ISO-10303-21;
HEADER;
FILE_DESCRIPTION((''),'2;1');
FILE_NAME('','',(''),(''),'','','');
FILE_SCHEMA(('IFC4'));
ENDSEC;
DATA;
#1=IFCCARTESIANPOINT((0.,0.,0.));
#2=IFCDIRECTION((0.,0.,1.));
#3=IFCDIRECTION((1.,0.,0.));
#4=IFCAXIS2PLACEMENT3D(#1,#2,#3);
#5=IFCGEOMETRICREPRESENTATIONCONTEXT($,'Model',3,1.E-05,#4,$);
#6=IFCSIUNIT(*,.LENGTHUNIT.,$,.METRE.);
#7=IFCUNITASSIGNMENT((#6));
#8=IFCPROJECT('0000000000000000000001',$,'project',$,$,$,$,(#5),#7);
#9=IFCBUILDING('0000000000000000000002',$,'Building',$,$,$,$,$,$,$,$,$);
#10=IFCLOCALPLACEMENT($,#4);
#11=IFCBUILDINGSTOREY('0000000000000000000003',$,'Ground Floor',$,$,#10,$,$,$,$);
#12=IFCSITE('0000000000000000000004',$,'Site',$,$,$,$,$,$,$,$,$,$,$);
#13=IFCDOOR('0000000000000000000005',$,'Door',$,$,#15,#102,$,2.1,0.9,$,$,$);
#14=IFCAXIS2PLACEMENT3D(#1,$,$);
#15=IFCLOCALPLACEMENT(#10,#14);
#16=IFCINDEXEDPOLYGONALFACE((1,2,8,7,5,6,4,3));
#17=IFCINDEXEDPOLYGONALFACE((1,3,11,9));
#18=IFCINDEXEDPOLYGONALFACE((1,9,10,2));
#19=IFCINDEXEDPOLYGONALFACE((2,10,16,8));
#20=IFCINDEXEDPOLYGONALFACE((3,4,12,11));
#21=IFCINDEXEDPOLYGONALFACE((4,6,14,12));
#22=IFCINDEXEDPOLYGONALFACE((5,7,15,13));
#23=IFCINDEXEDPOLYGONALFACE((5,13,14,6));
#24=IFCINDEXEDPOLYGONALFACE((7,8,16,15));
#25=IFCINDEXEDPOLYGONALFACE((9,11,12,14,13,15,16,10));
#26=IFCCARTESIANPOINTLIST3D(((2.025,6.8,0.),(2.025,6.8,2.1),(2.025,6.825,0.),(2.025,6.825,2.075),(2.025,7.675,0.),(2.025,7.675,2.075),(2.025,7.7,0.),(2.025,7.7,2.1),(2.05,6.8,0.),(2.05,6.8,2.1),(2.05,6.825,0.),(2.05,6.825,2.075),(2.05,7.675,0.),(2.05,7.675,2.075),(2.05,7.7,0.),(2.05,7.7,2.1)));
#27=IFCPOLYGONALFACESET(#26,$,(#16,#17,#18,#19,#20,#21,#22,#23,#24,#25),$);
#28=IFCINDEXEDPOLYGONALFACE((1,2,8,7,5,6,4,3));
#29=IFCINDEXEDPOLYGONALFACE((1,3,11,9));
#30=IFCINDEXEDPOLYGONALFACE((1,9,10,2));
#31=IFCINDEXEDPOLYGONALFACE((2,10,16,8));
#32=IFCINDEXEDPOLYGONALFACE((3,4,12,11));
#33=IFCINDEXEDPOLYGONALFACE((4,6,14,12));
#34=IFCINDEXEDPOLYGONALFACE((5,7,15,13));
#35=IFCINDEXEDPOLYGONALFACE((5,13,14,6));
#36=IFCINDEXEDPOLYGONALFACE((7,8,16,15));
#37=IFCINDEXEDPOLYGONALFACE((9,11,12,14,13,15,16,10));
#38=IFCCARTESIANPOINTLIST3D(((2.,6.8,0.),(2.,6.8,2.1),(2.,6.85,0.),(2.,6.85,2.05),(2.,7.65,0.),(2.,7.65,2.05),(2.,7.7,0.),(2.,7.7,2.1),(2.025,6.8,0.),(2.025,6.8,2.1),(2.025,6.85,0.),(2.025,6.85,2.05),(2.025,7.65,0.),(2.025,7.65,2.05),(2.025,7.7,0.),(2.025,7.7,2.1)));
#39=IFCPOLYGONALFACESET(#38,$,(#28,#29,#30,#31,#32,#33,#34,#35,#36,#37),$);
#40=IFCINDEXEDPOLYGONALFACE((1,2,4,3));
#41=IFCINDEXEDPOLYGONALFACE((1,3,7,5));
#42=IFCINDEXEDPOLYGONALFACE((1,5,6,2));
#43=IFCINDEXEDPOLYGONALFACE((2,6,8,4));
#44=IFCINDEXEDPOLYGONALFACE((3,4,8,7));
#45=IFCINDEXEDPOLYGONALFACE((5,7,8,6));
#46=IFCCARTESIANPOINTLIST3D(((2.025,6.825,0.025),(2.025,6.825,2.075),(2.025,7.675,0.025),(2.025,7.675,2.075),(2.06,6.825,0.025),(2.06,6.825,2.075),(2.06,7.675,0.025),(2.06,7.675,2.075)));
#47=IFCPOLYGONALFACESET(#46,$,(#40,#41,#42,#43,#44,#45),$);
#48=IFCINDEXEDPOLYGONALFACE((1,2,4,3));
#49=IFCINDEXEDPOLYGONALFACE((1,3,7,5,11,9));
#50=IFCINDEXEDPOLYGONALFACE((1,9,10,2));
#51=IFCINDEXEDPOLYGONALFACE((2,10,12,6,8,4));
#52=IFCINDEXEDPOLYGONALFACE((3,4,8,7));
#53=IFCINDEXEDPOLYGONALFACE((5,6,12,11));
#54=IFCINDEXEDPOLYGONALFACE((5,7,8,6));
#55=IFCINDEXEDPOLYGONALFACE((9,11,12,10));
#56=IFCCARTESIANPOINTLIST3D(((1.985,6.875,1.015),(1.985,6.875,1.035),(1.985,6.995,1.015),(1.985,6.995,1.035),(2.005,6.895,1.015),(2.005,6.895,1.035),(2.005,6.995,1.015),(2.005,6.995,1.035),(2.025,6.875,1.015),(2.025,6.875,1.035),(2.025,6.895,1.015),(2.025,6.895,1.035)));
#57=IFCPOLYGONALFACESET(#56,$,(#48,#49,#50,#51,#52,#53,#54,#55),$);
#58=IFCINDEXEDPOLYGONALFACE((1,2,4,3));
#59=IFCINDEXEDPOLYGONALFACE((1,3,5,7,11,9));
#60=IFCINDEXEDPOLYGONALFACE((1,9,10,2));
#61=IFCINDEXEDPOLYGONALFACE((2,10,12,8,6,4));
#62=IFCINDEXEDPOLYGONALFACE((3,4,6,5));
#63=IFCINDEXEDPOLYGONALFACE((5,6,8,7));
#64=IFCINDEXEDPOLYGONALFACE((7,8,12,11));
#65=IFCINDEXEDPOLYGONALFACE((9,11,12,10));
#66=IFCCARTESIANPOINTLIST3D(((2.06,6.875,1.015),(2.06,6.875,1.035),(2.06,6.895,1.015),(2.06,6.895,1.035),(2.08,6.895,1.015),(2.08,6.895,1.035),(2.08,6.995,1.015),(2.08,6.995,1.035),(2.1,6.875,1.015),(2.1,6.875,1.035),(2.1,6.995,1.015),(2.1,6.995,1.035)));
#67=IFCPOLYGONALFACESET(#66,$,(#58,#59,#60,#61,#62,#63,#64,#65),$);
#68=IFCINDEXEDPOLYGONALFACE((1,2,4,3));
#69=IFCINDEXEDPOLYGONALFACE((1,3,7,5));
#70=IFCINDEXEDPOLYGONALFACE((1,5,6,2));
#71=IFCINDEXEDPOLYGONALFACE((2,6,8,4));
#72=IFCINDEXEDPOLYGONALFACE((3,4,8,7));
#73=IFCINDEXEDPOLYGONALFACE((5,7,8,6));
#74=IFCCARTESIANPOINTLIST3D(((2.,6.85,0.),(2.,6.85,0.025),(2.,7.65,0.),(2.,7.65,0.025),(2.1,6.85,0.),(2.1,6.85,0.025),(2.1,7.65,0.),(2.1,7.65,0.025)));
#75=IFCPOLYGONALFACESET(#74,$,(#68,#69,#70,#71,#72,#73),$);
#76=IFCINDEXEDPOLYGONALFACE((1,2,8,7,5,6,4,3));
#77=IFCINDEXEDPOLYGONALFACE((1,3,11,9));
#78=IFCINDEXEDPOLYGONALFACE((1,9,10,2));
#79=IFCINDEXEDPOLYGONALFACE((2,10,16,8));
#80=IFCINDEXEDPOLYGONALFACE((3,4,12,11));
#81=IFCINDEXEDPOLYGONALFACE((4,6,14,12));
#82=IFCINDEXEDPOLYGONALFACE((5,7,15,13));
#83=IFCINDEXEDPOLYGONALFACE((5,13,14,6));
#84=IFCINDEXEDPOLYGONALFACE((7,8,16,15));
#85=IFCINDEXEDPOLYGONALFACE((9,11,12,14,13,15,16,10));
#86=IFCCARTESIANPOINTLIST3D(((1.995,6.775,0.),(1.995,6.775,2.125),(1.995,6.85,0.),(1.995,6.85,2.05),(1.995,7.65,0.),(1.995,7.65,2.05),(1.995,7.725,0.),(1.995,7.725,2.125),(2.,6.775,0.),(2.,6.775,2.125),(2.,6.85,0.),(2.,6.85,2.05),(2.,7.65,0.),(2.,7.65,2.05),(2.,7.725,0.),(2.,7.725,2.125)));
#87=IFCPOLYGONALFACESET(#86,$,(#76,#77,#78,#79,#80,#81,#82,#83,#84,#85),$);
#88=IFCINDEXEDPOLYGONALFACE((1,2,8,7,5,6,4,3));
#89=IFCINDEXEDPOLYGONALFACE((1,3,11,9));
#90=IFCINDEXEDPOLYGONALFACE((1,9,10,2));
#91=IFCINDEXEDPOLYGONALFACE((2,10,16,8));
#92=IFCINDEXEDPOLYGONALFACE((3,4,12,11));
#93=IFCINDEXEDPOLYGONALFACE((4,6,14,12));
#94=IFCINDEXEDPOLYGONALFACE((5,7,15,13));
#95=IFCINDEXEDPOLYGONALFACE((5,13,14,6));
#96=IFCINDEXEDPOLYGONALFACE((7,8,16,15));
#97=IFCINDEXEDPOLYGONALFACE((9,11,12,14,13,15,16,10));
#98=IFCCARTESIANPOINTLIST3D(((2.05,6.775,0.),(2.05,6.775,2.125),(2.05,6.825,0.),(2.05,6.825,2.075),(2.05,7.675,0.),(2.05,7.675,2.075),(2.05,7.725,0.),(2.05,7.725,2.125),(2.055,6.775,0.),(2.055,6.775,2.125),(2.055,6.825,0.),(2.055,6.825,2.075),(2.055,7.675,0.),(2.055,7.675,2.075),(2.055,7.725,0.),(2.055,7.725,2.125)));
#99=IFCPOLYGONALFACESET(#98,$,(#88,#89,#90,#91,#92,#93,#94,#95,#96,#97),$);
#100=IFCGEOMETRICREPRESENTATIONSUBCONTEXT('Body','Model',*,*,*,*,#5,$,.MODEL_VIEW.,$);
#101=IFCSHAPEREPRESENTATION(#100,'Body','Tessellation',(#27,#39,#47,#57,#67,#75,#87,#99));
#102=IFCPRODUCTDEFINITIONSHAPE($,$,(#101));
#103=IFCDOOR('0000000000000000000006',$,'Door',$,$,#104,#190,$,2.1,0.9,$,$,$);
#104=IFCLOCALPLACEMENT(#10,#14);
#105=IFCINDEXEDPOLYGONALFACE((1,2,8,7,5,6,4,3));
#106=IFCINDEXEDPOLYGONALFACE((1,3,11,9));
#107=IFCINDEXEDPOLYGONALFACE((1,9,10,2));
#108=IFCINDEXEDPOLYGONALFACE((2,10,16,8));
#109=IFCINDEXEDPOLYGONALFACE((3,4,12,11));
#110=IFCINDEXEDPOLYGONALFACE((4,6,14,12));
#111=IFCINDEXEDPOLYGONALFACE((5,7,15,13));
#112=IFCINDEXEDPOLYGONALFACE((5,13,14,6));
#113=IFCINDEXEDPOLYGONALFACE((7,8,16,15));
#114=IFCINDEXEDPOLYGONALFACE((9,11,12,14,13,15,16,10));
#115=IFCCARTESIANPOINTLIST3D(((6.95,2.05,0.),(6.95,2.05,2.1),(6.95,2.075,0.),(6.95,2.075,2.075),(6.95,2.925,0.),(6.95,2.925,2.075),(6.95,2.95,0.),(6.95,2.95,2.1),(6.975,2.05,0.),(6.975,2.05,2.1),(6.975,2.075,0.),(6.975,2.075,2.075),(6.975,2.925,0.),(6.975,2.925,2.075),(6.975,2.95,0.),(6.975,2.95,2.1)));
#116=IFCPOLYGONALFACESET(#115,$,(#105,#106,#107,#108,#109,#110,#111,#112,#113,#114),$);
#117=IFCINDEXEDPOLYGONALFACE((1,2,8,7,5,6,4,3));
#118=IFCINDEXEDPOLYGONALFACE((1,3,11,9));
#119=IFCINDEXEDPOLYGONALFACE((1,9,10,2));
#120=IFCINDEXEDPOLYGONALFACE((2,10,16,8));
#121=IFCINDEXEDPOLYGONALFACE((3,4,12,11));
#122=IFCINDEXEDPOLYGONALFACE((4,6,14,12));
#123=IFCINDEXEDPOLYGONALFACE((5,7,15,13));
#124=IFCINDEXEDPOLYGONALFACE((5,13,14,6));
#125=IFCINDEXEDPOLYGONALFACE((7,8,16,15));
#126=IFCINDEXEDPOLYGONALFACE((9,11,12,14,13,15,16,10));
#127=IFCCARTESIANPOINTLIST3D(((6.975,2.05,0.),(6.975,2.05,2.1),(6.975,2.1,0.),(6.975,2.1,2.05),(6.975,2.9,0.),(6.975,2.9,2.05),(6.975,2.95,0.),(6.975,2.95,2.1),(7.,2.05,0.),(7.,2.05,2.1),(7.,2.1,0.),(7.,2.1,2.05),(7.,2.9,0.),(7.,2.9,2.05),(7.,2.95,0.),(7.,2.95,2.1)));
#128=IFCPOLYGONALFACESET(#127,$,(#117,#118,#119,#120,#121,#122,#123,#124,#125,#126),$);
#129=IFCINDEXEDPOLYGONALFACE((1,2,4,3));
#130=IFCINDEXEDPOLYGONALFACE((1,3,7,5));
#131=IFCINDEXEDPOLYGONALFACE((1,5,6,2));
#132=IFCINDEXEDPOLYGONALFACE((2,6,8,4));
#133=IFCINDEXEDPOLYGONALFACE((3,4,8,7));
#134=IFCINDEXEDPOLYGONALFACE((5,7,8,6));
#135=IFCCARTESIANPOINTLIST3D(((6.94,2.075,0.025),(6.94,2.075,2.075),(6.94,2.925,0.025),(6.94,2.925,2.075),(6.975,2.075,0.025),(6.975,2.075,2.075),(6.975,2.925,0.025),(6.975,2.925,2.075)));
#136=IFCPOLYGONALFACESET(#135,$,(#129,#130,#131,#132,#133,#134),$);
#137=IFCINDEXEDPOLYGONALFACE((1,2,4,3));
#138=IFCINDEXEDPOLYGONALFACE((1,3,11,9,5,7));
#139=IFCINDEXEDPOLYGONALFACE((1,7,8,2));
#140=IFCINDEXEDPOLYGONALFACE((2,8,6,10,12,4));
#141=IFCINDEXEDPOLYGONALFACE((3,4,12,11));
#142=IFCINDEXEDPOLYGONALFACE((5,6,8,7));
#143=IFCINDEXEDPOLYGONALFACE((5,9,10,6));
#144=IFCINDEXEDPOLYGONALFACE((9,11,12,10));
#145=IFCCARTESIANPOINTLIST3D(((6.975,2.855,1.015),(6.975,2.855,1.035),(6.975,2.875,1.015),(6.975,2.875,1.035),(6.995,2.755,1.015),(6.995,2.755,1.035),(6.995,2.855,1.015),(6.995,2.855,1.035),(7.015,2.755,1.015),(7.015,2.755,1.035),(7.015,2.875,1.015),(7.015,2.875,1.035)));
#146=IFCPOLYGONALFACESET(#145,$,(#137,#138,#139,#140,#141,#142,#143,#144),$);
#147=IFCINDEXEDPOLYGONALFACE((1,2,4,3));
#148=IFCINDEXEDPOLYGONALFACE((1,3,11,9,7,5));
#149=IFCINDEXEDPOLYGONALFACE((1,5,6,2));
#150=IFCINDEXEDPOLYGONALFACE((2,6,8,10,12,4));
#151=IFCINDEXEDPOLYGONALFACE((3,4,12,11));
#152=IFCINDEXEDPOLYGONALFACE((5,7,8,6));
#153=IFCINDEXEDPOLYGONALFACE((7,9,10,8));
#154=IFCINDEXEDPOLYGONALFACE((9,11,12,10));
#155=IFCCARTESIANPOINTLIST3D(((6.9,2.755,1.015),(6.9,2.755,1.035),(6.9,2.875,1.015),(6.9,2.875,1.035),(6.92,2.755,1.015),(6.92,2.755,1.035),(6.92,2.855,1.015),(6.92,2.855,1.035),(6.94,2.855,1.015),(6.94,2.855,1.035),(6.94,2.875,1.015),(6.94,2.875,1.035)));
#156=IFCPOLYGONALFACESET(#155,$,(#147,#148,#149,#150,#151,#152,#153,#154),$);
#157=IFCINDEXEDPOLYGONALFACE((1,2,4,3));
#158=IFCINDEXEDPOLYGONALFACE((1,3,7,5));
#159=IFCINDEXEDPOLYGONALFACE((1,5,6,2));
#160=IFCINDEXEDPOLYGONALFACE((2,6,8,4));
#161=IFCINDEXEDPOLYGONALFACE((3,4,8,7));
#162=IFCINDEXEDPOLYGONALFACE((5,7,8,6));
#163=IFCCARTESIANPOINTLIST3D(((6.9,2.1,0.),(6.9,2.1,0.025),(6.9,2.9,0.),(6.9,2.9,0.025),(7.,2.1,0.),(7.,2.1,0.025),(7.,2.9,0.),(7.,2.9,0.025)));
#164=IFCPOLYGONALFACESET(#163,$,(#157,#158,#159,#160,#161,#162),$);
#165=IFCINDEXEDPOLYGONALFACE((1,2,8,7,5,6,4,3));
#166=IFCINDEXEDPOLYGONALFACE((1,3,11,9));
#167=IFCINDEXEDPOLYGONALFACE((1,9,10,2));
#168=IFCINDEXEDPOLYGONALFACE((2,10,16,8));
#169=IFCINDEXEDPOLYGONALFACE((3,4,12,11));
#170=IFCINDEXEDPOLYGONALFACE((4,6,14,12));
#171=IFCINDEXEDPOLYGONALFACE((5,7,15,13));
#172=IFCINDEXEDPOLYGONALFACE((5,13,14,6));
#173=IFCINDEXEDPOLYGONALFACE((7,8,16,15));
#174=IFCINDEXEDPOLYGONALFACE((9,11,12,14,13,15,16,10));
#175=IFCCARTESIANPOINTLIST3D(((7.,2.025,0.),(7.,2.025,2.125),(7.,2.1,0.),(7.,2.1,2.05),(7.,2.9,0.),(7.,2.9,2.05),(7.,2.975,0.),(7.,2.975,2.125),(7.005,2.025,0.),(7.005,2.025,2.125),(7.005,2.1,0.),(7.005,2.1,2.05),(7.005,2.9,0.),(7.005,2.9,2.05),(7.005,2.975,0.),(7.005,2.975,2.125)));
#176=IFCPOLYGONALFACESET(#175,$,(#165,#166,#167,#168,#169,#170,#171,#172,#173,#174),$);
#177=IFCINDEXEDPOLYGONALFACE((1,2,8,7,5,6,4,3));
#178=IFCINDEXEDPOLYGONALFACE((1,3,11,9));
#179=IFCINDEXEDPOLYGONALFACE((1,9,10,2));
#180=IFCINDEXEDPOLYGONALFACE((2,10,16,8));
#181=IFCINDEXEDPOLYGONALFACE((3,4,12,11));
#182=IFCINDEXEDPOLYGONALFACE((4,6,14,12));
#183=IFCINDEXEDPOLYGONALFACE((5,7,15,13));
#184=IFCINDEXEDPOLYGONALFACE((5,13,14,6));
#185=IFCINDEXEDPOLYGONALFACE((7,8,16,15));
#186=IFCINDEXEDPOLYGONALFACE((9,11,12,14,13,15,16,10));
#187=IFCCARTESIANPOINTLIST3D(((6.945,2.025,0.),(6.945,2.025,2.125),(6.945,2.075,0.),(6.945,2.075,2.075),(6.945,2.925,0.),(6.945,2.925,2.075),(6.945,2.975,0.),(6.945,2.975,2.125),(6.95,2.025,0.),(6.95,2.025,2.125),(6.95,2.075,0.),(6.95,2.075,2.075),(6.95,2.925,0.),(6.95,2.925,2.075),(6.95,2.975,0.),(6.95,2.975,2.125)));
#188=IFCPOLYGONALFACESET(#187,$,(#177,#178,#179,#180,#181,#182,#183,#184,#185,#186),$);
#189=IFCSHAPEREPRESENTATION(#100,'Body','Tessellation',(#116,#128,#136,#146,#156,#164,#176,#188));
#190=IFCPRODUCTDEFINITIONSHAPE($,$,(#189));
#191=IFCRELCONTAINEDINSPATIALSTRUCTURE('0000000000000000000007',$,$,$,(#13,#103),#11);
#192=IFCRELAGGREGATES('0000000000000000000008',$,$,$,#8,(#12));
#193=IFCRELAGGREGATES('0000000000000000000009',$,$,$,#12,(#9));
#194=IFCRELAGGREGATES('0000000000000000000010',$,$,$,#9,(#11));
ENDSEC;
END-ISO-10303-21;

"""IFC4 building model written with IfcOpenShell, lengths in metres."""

from ifc_helpers import new_model, si_unit, frame, origin_with_axes, place, context, subcontext, project, spatial, line, indexed_curve, outline, extrude, element, save


model = new_model("IFC4")

# Units and contexts
model_context = context("Model", 3, precision=1e-05, world=origin_with_axes())
body_context = subcontext(model_context, "Body", "Model", "MODEL_VIEW")
ifc_project = project(units=[si_unit("LENGTHUNIT", "METRE")], contexts=[model_context])

# Site, building, storey
site = spatial("IfcSite", under=ifc_project, Name="Site")
building = spatial("IfcBuilding", under=site, Name="Building")
storey_placement = place(None, origin_with_axes())
storey = spatial("IfcBuildingStorey", under=building, at=storey_placement, Name="Ground Floor")

# Doors
door_1_placement = place(storey_placement, frame((2.0, 7.7, 0.0), z_axis=(0.0, 0.0, 1.0), x_axis=(0.0, -1.0, 0.0)))
element("IfcDoor", 1, at=door_1_placement, inside=storey, Name="Door", OverallHeight=2.1, OverallWidth=0.9, context=body_context, shape_type="SweptSolid", body=[
    extrude(outline(indexed_curve([(0.0, 0.0), (0.0, 2.1), (0.9, 2.1), (0.9, 0.0), (0.875, 0.0), (0.875, 2.075), (0.025, 2.075), (0.025, 0.0)], segments=[line(1, 2, 3, 4, 5, 6, 7, 8, 1)])), frame((0.0, 0.025, 0.0), z_axis=(0.0, -1.0, 0.0), x_axis=(1.0, 0.0, 0.0)), (0.0, 0.0, -1.0), 0.025),
    extrude(outline(indexed_curve([(0.0, 0.0), (0.0, 2.1), (0.9, 2.1), (0.9, 0.0), (0.85, 0.0), (0.85, 2.05), (0.05, 2.05), (0.05, 0.0)], segments=[line(1, 2, 3, 4, 5, 6, 7, 8, 1)])), frame((0.0, 0.0, 0.0), z_axis=(0.0, -1.0, 0.0), x_axis=(1.0, 0.0, 0.0)), (0.0, 0.0, -1.0), 0.025),
    extrude(outline(indexed_curve([(0.0, 0.0), (0.85, 0.0), (0.85, 0.035), (0.0, 0.035)], segments=[line(1, 2, 3, 4, 1)])), frame((0.025, 0.025, 0.025), z_axis=(0.0, 0.0, 1.0), x_axis=(1.0, 0.0, 0.0)), (0.0, 0.0, 1.0), 2.05),
    extrude(outline(indexed_curve([(0.0, 0.0), (0.0, -0.04), (-0.12, -0.04), (-0.12, -0.02), (-0.02, -0.02), (-0.02, 0.0)], segments=[line(1, 2, 3, 4, 5, 6, 1)])), frame((0.825, 0.025, 1.015), z_axis=(0.0, 0.0, 1.0), x_axis=(1.0, 0.0, 0.0)), (0.0, 0.0, 1.0), 0.02),
    extrude(outline(indexed_curve([(0.0, 0.0), (0.0, 0.04), (-0.12, 0.04), (-0.12, 0.02), (-0.02, 0.02), (-0.02, 0.0)], segments=[line(1, 2, 3, 4, 5, 6, 1)])), frame((0.825, 0.06, 1.015), z_axis=(0.0, 0.0, 1.0), x_axis=(1.0, 0.0, 0.0)), (0.0, 0.0, 1.0), 0.02),
    extrude(outline(indexed_curve([(0.0, 0.0), (0.8, 0.0), (0.8, 0.1), (0.0, 0.1)], segments=[line(1, 2, 3, 4, 1)])), frame((0.05, 0.0, 0.0), z_axis=(0.0, 0.0, 1.0), x_axis=(1.0, 0.0, 0.0)), (0.0, 0.0, 1.0), 0.025),
    extrude(outline(indexed_curve([(0.0, 0.0), (0.0, 2.125), (0.95, 2.125), (0.95, 0.0), (0.875, 0.0), (0.875, 2.05), (0.075, 2.05), (0.075, 0.0)], segments=[line(1, 2, 3, 4, 5, 6, 7, 8, 1)])), frame((-0.025, -0.005, 0.0), z_axis=(0.0, -1.0, 0.0), x_axis=(1.0, 0.0, 0.0)), (0.0, 0.0, -1.0), 0.005),
    extrude(outline(indexed_curve([(0.0, 0.0), (0.0, 2.125), (0.95, 2.125), (0.95, 0.0), (0.9, 0.0), (0.9, 2.075), (0.05, 2.075), (0.05, 0.0)], segments=[line(1, 2, 3, 4, 5, 6, 7, 8, 1)])), frame((-0.025, 0.05, 0.0), z_axis=(0.0, -1.0, 0.0), x_axis=(1.0, 0.0, 0.0)), (0.0, 0.0, -1.0), 0.005),
])
door_2_placement = place(storey_placement, frame((7.0, 2.05, 0.0), z_axis=(0.0, 0.0, 1.0), x_axis=(0.0, 1.0, 0.0)))
element("IfcDoor", 2, at=door_2_placement, inside=storey, Name="Door", OverallHeight=2.1, OverallWidth=0.9, context=body_context, shape_type="SweptSolid", body=[
    extrude(outline(indexed_curve([(0.0, 0.0), (0.0, 2.1), (0.9, 2.1), (0.9, 0.0), (0.875, 0.0), (0.875, 2.075), (0.025, 2.075), (0.025, 0.0)], segments=[line(1, 2, 3, 4, 5, 6, 7, 8, 1)])), frame((0.0, 0.025, 0.0), z_axis=(0.0, -1.0, 0.0), x_axis=(1.0, 0.0, 0.0)), (0.0, 0.0, -1.0), 0.025),
    extrude(outline(indexed_curve([(0.0, 0.0), (0.0, 2.1), (0.9, 2.1), (0.9, 0.0), (0.85, 0.0), (0.85, 2.05), (0.05, 2.05), (0.05, 0.0)], segments=[line(1, 2, 3, 4, 5, 6, 7, 8, 1)])), frame((0.0, 0.0, 0.0), z_axis=(0.0, -1.0, 0.0), x_axis=(1.0, 0.0, 0.0)), (0.0, 0.0, -1.0), 0.025),
    extrude(outline(indexed_curve([(0.0, 0.0), (0.85, 0.0), (0.85, 0.035), (0.0, 0.035)], segments=[line(1, 2, 3, 4, 1)])), frame((0.025, 0.025, 0.025), z_axis=(0.0, 0.0, 1.0), x_axis=(1.0, 0.0, 0.0)), (0.0, 0.0, 1.0), 2.05),
    extrude(outline(indexed_curve([(0.0, 0.0), (0.0, -0.04), (-0.12, -0.04), (-0.12, -0.02), (-0.02, -0.02), (-0.02, 0.0)], segments=[line(1, 2, 3, 4, 5, 6, 1)])), frame((0.825, 0.025, 1.015), z_axis=(0.0, 0.0, 1.0), x_axis=(1.0, 0.0, 0.0)), (0.0, 0.0, 1.0), 0.02),
    extrude(outline(indexed_curve([(0.0, 0.0), (0.0, 0.04), (-0.12, 0.04), (-0.12, 0.02), (-0.02, 0.02), (-0.02, 0.0)], segments=[line(1, 2, 3, 4, 5, 6, 1)])), frame((0.825, 0.06, 1.015), z_axis=(0.0, 0.0, 1.0), x_axis=(1.0, 0.0, 0.0)), (0.0, 0.0, 1.0), 0.02),
    extrude(outline(indexed_curve([(0.0, 0.0), (0.8, 0.0), (0.8, 0.1), (0.0, 0.1)], segments=[line(1, 2, 3, 4, 1)])), frame((0.05, 0.0, 0.0), z_axis=(0.0, 0.0, 1.0), x_axis=(1.0, 0.0, 0.0)), (0.0, 0.0, 1.0), 0.025),
    extrude(outline(indexed_curve([(0.0, 0.0), (0.0, 2.125), (0.95, 2.125), (0.95, 0.0), (0.875, 0.0), (0.875, 2.05), (0.075, 2.05), (0.075, 0.0)], segments=[line(1, 2, 3, 4, 5, 6, 7, 8, 1)])), frame((-0.025, -0.005, 0.0), z_axis=(0.0, -1.0, 0.0), x_axis=(1.0, 0.0, 0.0)), (0.0, 0.0, -1.0), 0.005),
    extrude(outline(indexed_curve([(0.0, 0.0), (0.0, 2.125), (0.95, 2.125), (0.95, 0.0), (0.9, 0.0), (0.9, 2.075), (0.05, 2.075), (0.05, 0.0)], segments=[line(1, 2, 3, 4, 5, 6, 7, 8, 1)])), frame((-0.025, 0.05, 0.0), z_axis=(0.0, -1.0, 0.0), x_axis=(1.0, 0.0, 0.0)), (0.0, 0.0, -1.0), 0.005),
])

save(model, "model.ifc")
